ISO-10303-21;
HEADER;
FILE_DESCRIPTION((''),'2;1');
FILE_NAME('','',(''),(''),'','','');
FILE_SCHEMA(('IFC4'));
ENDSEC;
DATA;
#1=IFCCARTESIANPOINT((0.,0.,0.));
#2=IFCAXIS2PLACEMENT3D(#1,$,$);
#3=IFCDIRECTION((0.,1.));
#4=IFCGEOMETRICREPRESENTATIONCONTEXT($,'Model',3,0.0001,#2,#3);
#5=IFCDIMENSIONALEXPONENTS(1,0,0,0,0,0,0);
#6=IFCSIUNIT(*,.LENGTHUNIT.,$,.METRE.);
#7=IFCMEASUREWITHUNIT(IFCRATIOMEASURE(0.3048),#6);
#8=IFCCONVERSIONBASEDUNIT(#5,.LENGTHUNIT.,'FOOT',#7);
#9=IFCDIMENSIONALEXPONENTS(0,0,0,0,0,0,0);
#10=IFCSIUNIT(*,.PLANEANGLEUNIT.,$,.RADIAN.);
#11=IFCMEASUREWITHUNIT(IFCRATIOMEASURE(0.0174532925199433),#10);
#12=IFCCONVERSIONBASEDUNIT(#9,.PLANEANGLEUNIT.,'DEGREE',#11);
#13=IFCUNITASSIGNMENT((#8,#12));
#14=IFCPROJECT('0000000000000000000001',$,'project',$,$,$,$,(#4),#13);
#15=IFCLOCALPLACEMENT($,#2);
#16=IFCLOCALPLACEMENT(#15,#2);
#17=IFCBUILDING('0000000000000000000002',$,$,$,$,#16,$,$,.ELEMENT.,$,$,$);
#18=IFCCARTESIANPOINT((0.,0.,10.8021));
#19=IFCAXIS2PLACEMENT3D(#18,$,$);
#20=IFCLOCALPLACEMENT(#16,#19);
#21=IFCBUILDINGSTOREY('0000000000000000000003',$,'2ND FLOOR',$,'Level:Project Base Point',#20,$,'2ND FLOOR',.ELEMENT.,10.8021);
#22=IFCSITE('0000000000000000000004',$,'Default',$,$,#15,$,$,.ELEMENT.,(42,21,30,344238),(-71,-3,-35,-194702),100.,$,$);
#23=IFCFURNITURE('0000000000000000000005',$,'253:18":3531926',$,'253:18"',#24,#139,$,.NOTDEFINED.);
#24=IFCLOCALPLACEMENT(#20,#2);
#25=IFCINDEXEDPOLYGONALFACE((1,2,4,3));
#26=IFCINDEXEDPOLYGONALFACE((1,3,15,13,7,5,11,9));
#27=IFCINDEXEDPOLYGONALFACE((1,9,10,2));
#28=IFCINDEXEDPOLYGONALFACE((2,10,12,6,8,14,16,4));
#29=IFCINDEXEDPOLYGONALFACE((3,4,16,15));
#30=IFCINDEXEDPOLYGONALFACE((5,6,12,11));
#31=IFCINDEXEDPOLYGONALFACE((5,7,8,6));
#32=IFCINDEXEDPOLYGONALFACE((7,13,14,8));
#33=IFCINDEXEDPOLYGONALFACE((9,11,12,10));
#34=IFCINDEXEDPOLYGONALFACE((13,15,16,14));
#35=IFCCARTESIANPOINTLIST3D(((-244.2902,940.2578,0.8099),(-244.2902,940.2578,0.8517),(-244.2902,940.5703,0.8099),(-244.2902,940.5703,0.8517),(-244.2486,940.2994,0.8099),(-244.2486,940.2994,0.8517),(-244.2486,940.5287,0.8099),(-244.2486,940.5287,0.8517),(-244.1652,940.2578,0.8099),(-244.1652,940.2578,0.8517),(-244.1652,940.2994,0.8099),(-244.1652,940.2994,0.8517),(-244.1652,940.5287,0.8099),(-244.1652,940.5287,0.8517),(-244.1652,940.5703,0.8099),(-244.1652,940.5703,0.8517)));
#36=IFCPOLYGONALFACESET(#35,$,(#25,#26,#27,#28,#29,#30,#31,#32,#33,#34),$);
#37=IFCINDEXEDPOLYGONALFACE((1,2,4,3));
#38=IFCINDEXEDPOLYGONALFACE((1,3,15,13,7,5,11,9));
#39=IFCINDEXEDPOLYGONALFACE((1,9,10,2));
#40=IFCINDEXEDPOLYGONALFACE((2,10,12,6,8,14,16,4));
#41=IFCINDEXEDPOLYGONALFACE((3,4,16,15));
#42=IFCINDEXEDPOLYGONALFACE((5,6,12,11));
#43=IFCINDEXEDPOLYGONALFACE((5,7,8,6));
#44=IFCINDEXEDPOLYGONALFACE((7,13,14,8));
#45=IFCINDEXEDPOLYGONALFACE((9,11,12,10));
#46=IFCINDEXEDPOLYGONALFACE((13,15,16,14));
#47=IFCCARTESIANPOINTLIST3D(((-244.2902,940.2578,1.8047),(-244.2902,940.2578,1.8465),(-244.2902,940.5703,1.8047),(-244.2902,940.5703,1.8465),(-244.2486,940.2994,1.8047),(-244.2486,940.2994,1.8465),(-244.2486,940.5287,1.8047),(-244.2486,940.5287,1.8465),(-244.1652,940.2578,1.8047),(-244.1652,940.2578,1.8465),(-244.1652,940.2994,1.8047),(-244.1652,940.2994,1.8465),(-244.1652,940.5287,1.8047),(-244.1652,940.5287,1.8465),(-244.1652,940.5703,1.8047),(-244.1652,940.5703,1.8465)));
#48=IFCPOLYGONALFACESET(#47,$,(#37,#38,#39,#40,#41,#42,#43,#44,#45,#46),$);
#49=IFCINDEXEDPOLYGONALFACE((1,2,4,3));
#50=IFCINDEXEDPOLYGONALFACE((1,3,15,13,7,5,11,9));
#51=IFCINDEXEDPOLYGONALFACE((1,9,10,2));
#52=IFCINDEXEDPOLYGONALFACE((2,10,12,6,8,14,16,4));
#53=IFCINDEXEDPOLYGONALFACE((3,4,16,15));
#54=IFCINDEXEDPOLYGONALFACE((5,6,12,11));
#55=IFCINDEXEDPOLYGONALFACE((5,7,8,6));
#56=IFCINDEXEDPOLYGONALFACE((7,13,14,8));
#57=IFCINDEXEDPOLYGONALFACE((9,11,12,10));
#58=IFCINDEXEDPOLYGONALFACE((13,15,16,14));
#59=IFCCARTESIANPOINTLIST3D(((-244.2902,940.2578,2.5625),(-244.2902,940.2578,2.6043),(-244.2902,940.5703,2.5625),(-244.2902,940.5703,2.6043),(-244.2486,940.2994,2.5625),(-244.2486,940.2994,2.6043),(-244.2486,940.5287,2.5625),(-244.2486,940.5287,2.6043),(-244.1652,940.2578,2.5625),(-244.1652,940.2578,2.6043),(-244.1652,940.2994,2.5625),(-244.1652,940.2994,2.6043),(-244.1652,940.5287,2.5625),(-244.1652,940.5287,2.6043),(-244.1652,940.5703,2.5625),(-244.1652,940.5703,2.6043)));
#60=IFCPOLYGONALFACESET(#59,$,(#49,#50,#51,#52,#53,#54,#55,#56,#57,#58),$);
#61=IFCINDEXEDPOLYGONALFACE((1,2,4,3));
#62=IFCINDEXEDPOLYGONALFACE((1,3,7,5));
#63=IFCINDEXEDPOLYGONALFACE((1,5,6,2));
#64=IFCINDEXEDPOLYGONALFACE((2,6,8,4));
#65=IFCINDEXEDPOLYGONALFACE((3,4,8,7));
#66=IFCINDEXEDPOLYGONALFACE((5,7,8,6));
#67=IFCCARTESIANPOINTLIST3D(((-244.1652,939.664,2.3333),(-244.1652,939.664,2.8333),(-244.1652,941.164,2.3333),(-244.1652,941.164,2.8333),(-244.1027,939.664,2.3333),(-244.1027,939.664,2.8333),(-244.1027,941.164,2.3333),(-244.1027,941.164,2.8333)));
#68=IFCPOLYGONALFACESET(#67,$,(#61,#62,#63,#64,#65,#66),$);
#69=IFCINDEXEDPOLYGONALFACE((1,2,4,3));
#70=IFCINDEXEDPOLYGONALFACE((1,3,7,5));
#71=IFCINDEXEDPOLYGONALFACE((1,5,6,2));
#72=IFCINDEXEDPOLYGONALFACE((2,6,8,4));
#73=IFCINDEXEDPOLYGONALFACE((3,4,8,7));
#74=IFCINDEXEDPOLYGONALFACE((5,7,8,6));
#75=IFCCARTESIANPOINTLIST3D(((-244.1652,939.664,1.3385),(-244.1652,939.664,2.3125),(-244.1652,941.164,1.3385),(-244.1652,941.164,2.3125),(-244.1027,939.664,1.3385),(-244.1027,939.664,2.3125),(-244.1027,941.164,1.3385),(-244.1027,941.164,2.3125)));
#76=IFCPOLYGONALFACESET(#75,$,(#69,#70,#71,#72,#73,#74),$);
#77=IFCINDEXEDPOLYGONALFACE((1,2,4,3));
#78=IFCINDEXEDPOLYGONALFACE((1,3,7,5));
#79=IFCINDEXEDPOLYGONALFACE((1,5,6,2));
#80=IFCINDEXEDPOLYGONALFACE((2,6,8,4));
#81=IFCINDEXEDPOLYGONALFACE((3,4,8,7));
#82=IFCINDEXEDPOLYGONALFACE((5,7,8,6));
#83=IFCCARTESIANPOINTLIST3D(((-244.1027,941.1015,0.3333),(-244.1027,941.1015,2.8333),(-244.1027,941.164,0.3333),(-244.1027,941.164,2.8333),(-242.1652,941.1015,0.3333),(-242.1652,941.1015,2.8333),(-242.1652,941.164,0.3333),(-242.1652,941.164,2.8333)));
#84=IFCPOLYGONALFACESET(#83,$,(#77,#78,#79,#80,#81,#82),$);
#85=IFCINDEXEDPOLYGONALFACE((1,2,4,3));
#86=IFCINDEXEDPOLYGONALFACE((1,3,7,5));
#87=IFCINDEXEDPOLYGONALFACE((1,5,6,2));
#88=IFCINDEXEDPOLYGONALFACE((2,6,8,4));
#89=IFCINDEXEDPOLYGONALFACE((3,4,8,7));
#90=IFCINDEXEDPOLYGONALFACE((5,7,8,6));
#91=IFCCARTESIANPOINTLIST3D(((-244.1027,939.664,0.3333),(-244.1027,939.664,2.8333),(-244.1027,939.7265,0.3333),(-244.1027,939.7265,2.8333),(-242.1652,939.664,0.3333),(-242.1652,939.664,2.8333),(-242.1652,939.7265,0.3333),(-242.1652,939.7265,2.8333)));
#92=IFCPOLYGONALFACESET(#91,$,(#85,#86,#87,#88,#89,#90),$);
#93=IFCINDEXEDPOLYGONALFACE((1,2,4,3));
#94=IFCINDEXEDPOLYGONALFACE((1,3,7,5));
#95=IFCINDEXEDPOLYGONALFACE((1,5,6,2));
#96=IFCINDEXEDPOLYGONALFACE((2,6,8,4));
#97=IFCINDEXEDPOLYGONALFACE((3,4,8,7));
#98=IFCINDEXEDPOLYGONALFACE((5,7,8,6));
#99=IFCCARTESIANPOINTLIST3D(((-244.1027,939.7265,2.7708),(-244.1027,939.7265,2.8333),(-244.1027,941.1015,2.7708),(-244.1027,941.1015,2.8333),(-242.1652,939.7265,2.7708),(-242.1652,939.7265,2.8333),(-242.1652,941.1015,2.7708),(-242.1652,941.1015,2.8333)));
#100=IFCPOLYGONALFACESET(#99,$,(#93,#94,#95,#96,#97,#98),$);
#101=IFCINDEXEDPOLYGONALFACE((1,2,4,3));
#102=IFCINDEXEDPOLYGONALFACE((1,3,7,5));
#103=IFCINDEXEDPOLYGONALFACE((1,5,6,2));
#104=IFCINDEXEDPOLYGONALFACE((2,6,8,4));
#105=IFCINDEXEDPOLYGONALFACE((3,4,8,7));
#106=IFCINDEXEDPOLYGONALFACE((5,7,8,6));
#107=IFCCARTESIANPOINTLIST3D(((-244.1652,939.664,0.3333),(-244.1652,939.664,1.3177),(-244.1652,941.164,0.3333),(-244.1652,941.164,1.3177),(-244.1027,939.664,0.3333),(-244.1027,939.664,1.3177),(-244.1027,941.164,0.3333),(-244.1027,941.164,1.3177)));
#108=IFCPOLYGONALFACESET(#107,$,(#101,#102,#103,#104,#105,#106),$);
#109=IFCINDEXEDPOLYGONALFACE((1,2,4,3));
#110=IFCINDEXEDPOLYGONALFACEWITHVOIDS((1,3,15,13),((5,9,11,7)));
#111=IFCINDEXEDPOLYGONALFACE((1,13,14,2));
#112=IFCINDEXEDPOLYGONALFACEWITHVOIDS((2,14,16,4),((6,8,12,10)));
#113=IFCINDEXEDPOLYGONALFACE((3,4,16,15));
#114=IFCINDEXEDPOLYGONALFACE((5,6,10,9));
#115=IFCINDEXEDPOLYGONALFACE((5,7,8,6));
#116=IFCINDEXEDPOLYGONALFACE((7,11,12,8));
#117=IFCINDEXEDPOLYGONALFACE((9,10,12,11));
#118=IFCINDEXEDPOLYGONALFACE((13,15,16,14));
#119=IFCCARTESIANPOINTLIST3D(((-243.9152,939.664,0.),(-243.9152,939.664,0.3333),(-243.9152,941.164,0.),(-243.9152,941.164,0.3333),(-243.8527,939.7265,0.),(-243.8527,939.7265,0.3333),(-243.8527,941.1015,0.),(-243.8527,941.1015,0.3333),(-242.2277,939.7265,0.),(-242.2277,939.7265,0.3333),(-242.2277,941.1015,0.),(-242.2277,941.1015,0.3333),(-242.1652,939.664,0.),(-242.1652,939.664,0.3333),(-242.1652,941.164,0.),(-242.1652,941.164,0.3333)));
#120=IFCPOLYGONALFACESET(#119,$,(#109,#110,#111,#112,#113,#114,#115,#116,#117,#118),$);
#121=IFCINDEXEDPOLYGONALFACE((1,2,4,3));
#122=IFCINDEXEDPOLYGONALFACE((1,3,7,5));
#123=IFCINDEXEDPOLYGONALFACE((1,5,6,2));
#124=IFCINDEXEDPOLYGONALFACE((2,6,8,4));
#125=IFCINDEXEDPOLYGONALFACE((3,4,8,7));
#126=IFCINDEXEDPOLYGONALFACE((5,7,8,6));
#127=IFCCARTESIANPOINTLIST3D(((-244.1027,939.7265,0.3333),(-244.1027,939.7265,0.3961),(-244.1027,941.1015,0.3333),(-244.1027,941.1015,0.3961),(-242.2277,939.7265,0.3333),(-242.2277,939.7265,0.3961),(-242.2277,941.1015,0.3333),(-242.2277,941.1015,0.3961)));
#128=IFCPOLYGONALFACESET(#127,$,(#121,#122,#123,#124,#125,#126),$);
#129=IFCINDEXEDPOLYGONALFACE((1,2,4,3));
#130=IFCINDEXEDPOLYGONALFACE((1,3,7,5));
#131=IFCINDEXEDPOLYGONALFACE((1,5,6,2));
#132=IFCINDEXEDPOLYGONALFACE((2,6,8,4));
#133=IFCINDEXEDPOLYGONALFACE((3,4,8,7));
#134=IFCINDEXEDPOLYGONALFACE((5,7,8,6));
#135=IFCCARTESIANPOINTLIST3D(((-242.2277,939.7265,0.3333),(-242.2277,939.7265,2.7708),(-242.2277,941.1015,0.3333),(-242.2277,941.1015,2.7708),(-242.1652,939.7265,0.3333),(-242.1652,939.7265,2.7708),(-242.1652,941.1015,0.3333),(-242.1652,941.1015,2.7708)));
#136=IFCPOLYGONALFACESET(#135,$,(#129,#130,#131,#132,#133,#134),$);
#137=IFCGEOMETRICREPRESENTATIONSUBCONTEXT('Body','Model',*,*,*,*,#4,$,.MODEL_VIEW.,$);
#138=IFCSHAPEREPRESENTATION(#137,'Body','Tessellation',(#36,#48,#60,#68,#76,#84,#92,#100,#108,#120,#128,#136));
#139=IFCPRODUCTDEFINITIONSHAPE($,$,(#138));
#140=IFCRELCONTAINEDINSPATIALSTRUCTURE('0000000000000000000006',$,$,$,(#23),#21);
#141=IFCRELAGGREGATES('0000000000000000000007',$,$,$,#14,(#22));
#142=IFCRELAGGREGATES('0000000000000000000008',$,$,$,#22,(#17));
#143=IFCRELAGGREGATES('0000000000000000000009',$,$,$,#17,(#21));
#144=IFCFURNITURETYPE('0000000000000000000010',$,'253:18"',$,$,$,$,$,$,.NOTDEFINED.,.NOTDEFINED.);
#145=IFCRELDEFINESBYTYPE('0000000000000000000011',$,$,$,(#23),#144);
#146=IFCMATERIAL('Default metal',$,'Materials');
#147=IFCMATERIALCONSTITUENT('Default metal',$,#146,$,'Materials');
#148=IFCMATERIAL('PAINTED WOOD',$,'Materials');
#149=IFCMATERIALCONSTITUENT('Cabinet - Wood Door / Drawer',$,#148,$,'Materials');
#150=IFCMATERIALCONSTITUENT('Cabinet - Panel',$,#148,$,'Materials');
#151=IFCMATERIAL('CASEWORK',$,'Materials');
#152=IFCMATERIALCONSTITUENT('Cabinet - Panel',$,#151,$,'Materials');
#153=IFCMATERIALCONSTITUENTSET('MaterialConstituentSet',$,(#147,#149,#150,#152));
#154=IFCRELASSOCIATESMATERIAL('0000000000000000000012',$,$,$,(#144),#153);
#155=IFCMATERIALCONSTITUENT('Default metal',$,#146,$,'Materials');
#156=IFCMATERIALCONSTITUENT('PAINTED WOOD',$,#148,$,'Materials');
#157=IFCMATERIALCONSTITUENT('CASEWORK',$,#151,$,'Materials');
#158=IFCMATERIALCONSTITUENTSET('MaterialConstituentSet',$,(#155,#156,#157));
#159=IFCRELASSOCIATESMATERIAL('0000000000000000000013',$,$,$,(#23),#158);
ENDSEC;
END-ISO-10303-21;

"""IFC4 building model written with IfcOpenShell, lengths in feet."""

from ifc_helpers import new_model, entity, si_unit, converted_unit, direction, frame, frame_2d, origin, origin_2d_with_axis, place, context, subcontext, project, spatial, polyline, rectangle, outline, extrude, source, transform, mapped, material, constituent, constituent_set, type_object, type_shapes, element, save


model = new_model("IFC4")

# Units and contexts
model_context = context("Model", 3, precision=0.0001, world=origin(), true_north=direction((0.0, 1.0)))
body_context = subcontext(model_context, "Body", "Model", "MODEL_VIEW")
ifc_project = project(units=[converted_unit("LENGTHUNIT", "FOOT", entity("IfcRatioMeasure", 0.3048), si_unit("LENGTHUNIT", "METRE"), dimensions=[1, 0, 0, 0, 0, 0, 0]), converted_unit("PLANEANGLEUNIT", "DEGREE", entity("IfcRatioMeasure", 0.0174532925199433), si_unit("PLANEANGLEUNIT", "RADIAN"), dimensions=[0, 0, 0, 0, 0, 0, 0])], contexts=[model_context])

# Site, building, storey
site_placement = place(None, origin())
site = spatial("IfcSite", under=ifc_project, at=site_placement, Name="Default", CompositionType="ELEMENT", RefLatitude=(42, 21, 30, 344238), RefLongitude=(-71, -3, -35, -194702), RefElevation=100.0)
building_placement = place(site_placement, origin())
building = spatial("IfcBuilding", under=site, at=building_placement, CompositionType="ELEMENT")
storey_placement = place(building_placement, frame((0.0, 0.0, 10.8021)))
storey = spatial("IfcBuildingStorey", under=building, at=storey_placement, Name="2ND FLOOR", ObjectType="Level:Project Base Point", LongName="2ND FLOOR", CompositionType="ELEMENT", Elevation=10.8021)

# Furniture
ifc_material_1 = material(Name="CASEWORK", Category="Materials")
ifc_material_2 = material(Name="PAINTED WOOD", Category="Materials")
ifc_material_3 = material(Name="Default metal", Category="Materials")
ifc_constituent_1 = constituent(ifc_material_3, Name="Default metal", Category="Materials")
ifc_constituent_2 = constituent(ifc_material_2, Name="PAINTED WOOD", Category="Materials")
ifc_constituent_3 = constituent(ifc_material_1, Name="CASEWORK", Category="Materials")
ifc_constituent_set_1 = constituent_set(constituents=[ifc_constituent_1, ifc_constituent_2, ifc_constituent_3], Name="MaterialConstituentSet")
ifc_constituent_4 = constituent(ifc_material_3, Name="Default metal", Category="Materials")
ifc_constituent_5 = constituent(ifc_material_2, Name="Cabinet - Wood Door / Drawer", Category="Materials")
ifc_constituent_6 = constituent(ifc_material_2, Name="Cabinet - Panel", Category="Materials")
ifc_constituent_7 = constituent(ifc_material_1, Name="Cabinet - Panel", Category="Materials")
ifc_constituent_set_2 = constituent_set(constituents=[ifc_constituent_4, ifc_constituent_5, ifc_constituent_6, ifc_constituent_7], Name="MaterialConstituentSet")
furniture_type_1 = type_object("IfcFurnitureType", Name="253:18\"", AssemblyPlace="NOTDEFINED", PredefinedType="NOTDEFINED", material=ifc_constituent_set_2)
shared_shape_1 = source(origin(), body_context, "Body", "SweptSolid", [
    extrude(outline(polyline([(-0.0521, -0.1562), (0.0729, -0.1562), (0.0729, 0.1562), (-0.0521, 0.1562), (-0.0521, 0.1146), (0.0313, 0.1146), (0.0313, -0.1146), (-0.0521, -0.1146), (-0.0521, -0.1562)])), frame((0.0615, -2.0521, 0.8099), z_axis=(0.0, 0.0, 1.0), x_axis=(0.0, -1.0, 0.0)), (0.0, 0.0, 1.0), 0.0418),
    extrude(outline(polyline([(-0.0521, -0.1562), (0.0729, -0.1562), (0.0729, 0.1562), (-0.0521, 0.1562), (-0.0521, 0.1146), (0.0313, 0.1146), (0.0313, -0.1146), (-0.0521, -0.1146), (-0.0521, -0.1562)])), frame((0.0615, -2.0521, 1.8047), z_axis=(0.0, 0.0, 1.0), x_axis=(0.0, -1.0, 0.0)), (0.0, 0.0, 1.0), 0.0418),
    extrude(outline(polyline([(-0.0521, -0.1562), (0.0729, -0.1562), (0.0729, 0.1562), (-0.0521, 0.1562), (-0.0521, 0.1146), (0.0313, 0.1146), (0.0313, -0.1146), (-0.0521, -0.1146), (-0.0521, -0.1562)])), frame((0.0615, -2.0521, 2.5625), z_axis=(0.0, 0.0, 1.0), x_axis=(0.0, -1.0, 0.0)), (0.0, 0.0, 1.0), 0.0418),
    extrude(rectangle(XDim=0.0625, YDim=1.5, at=frame_2d((0.0, 0.0), x_axis=(1.0, 0.0))), frame((0.0615, -1.9688, 2.3333), z_axis=(0.0, 0.0, 1.0), x_axis=(0.0, 1.0, 0.0)), (0.0, 0.0, 1.0), 0.5),
    extrude(rectangle(XDim=0.0625, YDim=1.5, at=frame_2d((0.0, 0.0), x_axis=(1.0, 0.0))), frame((0.0615, -1.9688, 1.3385), z_axis=(0.0, 0.0, 1.0), x_axis=(0.0, 1.0, 0.0)), (0.0, 0.0, 1.0), 0.974),
    extrude(rectangle(XDim=0.0625, YDim=1.9375, at=frame_2d((0.0, 0.0), x_axis=(1.0, 0.0))), frame((-0.6573, -0.9687, 0.3333)), (0.0, 0.0, 1.0), 2.5),
    extrude(rectangle(XDim=0.0625, YDim=1.9375, at=frame_2d((0.0, 0.0), x_axis=(1.0, 0.0))), frame((0.7802, -0.9687, 0.3333)), (0.0, 0.0, 1.0), 2.5),
    extrude(rectangle(XDim=1.375, YDim=1.9375, at=origin_2d_with_axis()), frame((0.0615, -0.9688, 2.7708), z_axis=(0.0, 0.0, 1.0), x_axis=(-1.0, 0.0, 0.0)), (0.0, 0.0, 1.0), 0.0625),
    extrude(rectangle(XDim=0.0625, YDim=1.5, at=frame_2d((0.0, 0.0), x_axis=(1.0, 0.0))), frame((0.0615, -1.9688, 0.3333), z_axis=(0.0, 0.0, 1.0), x_axis=(0.0, 1.0, 0.0)), (0.0, 0.0, 1.0), 0.9844),
    extrude(outline(polyline([(-0.75, -0.875), (0.75, -0.875), (0.75, 0.875), (-0.75, 0.875), (-0.75, -0.875)]), holes=[polyline([(-0.6875, -0.8125), (-0.6875, 0.8125), (0.6875, 0.8125), (0.6875, -0.8125), (-0.6875, -0.8125)])]), frame((0.0615, -0.875, 0.0)), (0.0, 0.0, 1.0), 0.3333),
    extrude(rectangle(XDim=1.375, YDim=1.875, at=frame_2d((0.0, 0.0), x_axis=(1.0, 0.0))), frame((0.0615, -1.0, 0.3333), z_axis=(0.0, 0.0, 1.0), x_axis=(-1.0, 0.0, 0.0)), (0.0, 0.0, 1.0), 0.0627),
    extrude(rectangle(XDim=0.0625, YDim=1.375, at=origin_2d_with_axis()), frame((0.0615, -0.0312, 0.3333), z_axis=(0.0, 0.0, 1.0), x_axis=(0.0, 1.0, 0.0)), (0.0, 0.0, 1.0), 2.4375),
])
type_shapes(furniture_type_1, [shared_shape_1])
furniture_1_placement = place(storey_placement, frame((-242.1652, 940.4755, 0.0), z_axis=(0.0, 0.0, 1.0), x_axis=(0.0, -1.0, 0.0)))
element("IfcFurniture", 1, at=furniture_1_placement, inside=storey, type_object=furniture_type_1, material=ifc_constituent_set_1, Name="253:18\":3531926", ObjectType="253:18\"", PredefinedType="NOTDEFINED", context=body_context, shape_type="MappedRepresentation", body=[
    mapped(shared_shape_1, transform((0.0, 0.0, 0.0), scale=1.0)),
])

save(model, "model.ifc")
